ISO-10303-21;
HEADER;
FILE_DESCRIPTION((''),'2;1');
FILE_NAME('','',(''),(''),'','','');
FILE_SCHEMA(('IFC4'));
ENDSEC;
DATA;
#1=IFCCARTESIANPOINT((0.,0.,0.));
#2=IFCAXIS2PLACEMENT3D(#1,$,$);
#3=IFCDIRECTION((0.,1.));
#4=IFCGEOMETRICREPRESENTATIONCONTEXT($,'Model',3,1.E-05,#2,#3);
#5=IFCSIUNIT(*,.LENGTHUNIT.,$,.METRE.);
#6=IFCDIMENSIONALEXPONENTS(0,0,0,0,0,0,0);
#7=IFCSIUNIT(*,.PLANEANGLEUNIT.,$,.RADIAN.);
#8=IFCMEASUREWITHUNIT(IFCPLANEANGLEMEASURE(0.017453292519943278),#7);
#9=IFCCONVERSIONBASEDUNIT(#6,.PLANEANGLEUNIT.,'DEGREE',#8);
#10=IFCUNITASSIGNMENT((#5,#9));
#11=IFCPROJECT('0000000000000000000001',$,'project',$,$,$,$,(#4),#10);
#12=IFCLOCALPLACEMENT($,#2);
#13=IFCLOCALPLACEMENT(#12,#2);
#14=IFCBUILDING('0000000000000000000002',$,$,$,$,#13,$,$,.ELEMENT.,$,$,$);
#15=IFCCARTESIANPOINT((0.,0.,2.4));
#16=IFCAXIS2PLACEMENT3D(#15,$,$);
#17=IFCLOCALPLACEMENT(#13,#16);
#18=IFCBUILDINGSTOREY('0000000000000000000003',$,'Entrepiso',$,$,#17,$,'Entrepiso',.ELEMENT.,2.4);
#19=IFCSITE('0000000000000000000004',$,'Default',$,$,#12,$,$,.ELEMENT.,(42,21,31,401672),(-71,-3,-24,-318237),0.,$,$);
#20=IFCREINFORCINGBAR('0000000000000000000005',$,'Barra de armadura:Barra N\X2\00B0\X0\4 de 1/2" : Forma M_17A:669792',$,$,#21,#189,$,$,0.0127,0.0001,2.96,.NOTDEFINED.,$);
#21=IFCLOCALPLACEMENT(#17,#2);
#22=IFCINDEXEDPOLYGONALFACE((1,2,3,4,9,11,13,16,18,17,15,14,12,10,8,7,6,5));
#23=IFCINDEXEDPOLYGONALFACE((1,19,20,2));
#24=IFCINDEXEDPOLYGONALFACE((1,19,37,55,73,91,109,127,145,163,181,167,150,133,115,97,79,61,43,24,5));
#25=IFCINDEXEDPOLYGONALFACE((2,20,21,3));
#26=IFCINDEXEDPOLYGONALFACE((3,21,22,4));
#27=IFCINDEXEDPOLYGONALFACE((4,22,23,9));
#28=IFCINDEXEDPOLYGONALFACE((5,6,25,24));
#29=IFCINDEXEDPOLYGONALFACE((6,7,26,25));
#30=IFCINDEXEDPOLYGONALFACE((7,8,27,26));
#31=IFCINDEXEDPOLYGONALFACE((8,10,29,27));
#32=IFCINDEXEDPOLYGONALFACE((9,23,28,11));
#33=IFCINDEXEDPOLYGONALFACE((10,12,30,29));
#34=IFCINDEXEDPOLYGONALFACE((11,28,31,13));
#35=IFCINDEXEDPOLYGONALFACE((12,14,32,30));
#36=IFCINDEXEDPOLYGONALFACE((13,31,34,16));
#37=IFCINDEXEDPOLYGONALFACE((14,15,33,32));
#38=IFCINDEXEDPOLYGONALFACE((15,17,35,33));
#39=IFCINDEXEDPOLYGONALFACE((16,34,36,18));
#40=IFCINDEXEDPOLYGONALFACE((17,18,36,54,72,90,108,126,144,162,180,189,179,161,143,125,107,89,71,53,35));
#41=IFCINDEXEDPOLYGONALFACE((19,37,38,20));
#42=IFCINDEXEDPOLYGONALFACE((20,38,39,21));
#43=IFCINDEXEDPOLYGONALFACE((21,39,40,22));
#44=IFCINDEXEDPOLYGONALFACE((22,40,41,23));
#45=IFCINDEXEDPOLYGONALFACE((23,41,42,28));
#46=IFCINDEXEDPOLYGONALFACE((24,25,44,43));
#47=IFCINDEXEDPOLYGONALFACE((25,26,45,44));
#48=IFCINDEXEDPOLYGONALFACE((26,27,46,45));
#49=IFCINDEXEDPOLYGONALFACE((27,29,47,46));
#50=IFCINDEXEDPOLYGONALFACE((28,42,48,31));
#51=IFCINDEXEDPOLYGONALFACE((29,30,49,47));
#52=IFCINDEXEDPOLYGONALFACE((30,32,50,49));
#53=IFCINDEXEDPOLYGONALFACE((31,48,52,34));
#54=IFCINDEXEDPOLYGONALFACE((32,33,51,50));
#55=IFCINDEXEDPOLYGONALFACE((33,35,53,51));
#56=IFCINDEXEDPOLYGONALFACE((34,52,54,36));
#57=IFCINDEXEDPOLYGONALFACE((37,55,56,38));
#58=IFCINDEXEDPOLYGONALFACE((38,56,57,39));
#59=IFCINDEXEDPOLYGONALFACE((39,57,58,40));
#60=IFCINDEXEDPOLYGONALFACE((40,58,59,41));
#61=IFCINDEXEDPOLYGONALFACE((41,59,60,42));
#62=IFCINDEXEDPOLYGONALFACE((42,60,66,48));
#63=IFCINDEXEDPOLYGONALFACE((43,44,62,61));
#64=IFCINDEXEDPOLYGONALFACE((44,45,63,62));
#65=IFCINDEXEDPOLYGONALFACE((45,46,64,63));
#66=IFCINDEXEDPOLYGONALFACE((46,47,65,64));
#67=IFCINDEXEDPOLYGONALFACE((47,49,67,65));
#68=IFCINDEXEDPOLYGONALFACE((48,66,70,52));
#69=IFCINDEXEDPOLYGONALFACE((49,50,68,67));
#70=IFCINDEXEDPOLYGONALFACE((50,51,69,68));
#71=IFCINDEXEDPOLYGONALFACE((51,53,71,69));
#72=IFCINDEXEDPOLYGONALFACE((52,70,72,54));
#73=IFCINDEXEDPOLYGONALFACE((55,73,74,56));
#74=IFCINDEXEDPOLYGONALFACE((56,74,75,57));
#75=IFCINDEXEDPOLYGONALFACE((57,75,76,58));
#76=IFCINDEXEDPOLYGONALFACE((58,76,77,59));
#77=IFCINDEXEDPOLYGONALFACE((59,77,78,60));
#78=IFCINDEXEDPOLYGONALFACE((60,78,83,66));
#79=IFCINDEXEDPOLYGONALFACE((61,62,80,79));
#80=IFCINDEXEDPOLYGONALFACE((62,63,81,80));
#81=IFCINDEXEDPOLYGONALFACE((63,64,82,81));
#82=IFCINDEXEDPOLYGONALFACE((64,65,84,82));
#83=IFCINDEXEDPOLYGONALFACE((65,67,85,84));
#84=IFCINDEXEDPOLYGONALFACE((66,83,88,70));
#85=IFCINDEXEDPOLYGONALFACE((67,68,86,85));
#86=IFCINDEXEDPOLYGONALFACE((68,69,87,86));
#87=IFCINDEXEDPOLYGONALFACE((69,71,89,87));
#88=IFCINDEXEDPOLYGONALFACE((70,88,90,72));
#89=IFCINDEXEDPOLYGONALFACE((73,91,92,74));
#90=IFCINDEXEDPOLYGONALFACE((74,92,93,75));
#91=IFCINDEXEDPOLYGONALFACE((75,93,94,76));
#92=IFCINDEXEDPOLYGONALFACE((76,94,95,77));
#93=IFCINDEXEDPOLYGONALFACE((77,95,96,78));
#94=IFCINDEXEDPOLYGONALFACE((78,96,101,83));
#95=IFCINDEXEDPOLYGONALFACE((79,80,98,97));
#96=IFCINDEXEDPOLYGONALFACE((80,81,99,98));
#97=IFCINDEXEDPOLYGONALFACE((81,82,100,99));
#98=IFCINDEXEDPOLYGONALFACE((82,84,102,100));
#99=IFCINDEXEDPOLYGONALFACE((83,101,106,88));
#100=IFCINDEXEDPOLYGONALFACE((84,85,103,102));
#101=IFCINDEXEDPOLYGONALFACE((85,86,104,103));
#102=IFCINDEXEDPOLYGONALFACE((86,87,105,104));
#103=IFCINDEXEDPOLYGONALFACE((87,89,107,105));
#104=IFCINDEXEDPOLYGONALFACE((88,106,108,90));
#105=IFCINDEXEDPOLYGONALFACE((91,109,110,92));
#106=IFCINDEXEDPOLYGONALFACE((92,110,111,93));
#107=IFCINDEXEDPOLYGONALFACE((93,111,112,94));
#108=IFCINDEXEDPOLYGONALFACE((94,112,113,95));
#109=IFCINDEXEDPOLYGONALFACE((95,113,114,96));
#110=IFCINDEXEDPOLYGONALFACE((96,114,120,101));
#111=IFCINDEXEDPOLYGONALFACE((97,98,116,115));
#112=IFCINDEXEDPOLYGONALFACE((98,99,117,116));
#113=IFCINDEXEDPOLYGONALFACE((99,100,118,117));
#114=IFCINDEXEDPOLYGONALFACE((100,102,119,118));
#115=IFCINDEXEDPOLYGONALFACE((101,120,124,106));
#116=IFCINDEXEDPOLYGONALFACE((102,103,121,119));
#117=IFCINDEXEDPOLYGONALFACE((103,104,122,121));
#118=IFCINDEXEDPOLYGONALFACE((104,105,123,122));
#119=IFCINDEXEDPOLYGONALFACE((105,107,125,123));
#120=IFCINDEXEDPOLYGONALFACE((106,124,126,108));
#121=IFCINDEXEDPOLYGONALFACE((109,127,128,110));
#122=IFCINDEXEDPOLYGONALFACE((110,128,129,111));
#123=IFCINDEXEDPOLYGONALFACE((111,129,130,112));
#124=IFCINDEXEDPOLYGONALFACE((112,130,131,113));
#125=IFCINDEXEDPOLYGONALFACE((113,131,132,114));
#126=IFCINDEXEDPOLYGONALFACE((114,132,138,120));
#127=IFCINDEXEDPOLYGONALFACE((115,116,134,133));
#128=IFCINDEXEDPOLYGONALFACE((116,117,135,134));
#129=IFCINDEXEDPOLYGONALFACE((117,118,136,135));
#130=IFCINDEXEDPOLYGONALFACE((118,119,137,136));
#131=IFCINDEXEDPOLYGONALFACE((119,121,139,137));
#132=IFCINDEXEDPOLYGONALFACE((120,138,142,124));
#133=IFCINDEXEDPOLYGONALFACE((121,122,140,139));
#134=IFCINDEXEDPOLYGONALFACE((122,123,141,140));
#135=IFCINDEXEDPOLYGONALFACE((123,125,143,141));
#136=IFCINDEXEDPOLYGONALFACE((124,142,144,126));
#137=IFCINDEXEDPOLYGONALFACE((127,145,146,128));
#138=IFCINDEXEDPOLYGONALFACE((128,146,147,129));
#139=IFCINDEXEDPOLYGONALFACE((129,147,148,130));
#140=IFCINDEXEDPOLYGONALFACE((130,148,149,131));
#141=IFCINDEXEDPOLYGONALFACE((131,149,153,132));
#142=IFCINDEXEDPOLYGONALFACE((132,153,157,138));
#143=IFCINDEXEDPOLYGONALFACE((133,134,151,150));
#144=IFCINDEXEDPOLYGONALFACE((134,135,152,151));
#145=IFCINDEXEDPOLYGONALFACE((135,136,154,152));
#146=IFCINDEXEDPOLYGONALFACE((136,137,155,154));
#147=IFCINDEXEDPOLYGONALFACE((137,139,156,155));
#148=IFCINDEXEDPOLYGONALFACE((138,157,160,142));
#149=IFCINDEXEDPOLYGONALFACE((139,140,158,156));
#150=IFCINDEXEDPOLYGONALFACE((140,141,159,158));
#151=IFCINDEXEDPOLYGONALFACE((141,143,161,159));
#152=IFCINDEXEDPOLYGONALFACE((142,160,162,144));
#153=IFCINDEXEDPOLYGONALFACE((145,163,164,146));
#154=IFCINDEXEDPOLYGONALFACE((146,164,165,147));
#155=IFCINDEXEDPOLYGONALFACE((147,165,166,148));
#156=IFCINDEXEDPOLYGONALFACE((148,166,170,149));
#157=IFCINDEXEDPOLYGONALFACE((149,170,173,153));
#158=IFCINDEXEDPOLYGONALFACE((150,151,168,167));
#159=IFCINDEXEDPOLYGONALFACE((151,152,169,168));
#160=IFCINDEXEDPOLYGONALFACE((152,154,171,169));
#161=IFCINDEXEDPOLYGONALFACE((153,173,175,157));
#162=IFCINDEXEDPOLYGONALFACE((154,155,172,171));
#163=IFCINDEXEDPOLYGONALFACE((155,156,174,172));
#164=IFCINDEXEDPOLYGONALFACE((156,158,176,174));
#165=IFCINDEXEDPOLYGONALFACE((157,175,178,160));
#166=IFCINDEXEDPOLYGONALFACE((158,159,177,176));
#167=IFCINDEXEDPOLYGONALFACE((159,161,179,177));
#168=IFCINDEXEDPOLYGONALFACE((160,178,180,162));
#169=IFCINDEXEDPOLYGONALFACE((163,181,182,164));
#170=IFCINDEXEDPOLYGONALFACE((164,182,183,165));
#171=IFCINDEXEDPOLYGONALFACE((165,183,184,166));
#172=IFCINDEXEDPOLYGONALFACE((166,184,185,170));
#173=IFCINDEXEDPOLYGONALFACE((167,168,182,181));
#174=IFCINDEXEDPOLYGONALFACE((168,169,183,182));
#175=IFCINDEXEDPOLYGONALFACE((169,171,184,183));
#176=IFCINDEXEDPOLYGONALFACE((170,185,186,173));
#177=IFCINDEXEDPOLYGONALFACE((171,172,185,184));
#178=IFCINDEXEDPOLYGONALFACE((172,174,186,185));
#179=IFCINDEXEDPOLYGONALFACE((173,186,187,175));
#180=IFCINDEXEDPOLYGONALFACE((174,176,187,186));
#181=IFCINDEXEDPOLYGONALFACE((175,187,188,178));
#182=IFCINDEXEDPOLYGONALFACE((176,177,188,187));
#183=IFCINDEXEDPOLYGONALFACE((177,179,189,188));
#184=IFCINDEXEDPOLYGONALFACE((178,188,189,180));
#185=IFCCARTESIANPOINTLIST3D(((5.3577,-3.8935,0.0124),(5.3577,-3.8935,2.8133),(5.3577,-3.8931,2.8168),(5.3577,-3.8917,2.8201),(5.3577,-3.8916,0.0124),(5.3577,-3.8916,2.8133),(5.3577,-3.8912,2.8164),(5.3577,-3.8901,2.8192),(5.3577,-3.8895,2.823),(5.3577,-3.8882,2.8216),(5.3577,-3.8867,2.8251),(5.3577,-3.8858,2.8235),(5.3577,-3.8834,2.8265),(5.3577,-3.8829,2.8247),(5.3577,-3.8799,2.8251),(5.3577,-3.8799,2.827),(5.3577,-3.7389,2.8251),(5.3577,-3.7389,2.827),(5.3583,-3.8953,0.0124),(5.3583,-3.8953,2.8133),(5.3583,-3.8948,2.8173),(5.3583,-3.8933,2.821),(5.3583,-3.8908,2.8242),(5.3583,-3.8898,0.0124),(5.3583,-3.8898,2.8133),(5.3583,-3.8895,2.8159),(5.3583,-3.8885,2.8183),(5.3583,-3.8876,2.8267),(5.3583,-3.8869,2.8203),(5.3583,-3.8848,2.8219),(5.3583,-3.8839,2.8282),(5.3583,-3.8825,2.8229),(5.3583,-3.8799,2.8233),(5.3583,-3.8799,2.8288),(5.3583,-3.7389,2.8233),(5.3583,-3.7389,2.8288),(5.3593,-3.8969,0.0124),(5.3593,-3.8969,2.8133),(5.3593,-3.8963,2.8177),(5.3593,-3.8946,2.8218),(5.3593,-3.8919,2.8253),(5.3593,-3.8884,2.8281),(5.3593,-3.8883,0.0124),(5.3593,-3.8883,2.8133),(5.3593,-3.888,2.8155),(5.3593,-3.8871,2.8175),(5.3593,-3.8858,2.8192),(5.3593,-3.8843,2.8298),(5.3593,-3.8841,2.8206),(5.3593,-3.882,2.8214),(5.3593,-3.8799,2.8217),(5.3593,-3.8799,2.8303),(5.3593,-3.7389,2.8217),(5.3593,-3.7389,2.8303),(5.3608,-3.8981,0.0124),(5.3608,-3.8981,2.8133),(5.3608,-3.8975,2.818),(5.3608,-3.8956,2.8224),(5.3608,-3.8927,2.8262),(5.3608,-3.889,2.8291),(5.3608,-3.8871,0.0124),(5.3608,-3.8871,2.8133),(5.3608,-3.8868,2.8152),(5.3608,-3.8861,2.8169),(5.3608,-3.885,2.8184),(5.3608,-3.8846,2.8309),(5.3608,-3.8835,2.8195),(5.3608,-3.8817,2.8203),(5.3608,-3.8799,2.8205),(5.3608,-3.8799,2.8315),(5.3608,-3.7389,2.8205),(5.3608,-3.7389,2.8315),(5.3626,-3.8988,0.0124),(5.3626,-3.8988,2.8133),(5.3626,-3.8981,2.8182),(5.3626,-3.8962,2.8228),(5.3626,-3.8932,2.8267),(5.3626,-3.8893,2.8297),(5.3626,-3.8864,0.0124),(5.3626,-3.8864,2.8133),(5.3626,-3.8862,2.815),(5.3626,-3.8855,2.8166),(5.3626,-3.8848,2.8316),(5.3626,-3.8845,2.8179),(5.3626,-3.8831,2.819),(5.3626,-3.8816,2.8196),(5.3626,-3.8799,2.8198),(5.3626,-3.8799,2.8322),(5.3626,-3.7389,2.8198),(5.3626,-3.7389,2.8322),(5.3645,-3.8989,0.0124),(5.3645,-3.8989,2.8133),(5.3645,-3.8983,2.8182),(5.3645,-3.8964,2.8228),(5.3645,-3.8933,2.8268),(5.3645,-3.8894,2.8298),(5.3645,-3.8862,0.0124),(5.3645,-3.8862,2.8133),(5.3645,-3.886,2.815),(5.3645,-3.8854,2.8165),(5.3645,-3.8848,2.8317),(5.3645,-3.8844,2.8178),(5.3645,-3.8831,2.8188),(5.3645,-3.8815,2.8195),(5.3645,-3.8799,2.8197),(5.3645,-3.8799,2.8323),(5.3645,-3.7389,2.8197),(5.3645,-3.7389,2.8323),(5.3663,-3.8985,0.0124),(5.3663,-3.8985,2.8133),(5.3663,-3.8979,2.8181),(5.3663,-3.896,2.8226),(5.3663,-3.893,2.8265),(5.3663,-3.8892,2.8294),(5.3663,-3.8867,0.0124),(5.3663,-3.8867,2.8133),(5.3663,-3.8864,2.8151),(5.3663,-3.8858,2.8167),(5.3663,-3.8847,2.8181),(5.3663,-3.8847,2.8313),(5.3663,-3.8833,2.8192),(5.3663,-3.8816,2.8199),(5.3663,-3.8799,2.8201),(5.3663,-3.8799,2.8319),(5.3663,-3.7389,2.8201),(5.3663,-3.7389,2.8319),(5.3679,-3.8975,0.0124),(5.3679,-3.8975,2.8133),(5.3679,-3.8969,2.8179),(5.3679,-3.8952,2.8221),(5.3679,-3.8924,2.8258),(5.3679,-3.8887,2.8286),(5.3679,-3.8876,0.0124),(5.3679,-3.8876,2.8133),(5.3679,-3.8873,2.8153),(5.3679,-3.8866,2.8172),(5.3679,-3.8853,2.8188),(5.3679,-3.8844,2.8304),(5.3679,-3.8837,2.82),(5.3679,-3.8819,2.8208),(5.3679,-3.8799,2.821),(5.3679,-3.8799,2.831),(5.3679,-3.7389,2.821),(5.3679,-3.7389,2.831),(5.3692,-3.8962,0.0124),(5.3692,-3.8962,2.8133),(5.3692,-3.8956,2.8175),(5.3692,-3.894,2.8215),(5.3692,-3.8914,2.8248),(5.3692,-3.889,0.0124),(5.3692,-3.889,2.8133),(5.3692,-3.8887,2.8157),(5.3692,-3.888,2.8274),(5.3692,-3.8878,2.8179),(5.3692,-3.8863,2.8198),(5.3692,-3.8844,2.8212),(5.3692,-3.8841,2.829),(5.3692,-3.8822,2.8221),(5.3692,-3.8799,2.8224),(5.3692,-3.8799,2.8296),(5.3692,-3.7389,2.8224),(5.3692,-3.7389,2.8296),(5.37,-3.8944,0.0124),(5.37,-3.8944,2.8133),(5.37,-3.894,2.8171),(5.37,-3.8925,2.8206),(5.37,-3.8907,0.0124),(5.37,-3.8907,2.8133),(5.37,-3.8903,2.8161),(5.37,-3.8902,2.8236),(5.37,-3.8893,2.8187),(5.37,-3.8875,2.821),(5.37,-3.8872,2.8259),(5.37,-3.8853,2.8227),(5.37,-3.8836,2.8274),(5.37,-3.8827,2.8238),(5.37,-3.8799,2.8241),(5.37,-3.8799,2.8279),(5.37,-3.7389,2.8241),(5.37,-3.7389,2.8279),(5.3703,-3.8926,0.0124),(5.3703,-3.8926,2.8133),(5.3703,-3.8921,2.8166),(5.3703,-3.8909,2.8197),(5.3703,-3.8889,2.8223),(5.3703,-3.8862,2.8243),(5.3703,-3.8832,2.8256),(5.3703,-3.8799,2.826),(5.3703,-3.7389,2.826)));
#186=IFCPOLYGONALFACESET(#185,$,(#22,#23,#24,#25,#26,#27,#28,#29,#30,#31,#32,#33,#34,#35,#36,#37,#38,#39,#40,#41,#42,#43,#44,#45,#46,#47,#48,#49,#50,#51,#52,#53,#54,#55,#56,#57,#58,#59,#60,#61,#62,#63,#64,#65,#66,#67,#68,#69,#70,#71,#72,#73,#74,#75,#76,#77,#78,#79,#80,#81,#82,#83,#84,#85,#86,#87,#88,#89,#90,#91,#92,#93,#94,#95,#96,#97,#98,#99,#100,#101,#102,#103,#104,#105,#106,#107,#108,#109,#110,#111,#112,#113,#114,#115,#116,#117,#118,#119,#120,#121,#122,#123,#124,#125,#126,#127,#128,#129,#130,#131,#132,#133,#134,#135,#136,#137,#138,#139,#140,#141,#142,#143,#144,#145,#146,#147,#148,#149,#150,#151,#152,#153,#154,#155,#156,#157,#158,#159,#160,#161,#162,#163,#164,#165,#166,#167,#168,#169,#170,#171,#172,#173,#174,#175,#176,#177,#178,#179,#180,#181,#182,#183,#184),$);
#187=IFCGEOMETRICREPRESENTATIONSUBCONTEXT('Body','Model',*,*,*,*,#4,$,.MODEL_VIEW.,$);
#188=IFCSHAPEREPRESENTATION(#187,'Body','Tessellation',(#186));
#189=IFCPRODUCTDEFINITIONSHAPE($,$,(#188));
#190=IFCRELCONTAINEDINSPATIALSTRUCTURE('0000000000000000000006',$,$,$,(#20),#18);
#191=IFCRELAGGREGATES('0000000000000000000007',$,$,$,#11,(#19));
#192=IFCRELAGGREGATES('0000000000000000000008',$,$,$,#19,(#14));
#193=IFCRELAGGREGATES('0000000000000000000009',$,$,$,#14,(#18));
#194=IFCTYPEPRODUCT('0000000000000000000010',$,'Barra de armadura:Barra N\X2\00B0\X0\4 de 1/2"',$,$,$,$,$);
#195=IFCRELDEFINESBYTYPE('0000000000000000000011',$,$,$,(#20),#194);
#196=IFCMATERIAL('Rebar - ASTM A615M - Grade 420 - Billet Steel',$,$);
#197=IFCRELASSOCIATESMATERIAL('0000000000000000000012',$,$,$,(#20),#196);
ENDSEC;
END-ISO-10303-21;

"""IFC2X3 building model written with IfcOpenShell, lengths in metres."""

from ifc_helpers import new_model, entity, si_unit, converted_unit, direction, frame, origin, place, context, subcontext, project, spatial, material, type_object, element, save


model = new_model("IFC2X3")

# Units and contexts
model_context = context("Model", 3, precision=1e-05, world=origin(), true_north=direction((0.0, 1.0)))
body_context = subcontext(model_context, "Body", "Model", "MODEL_VIEW")
ifc_project = project(units=[si_unit("LENGTHUNIT", "METRE"), converted_unit("PLANEANGLEUNIT", "DEGREE", entity("IfcPlaneAngleMeasure", 0.017453292519943278), si_unit("PLANEANGLEUNIT", "RADIAN"), dimensions=[0, 0, 0, 0, 0, 0, 0])], contexts=[model_context])

# Site, building, storey
site_placement = place(None, origin())
site = spatial("IfcSite", under=ifc_project, at=site_placement, Name="Default", CompositionType="ELEMENT", RefLatitude=(42, 21, 31, 401672), RefLongitude=(-71, -3, -24, -318237), RefElevation=0.0)
building_placement = place(site_placement, origin())
building = spatial("IfcBuilding", under=site, at=building_placement, CompositionType="ELEMENT")
storey_placement = place(building_placement, frame((0.0, 0.0, 2.4)))
storey = spatial("IfcBuildingStorey", under=building, at=storey_placement, Name="Entrepiso", LongName="Entrepiso", CompositionType="ELEMENT", Elevation=2.4)

# Reinforcing bar
ifc_material = material(Name="Rebar - ASTM A615M - Grade 420 - Billet Steel")
type_product_1 = type_object("IfcTypeProduct", Name="Barra de armadura:Barra N°4 de 1/2\"")
reinforcing_bar_1_placement = place(storey_placement, origin())
element("IfcReinforcingBar", 1, at=reinforcing_bar_1_placement, inside=storey, type_object=type_product_1, material=ifc_material, Name="Barra de armadura:Barra N°4 de 1/2\" : Forma M_17A:669792", BarLength=2.96, BarRole="NOTDEFINED", CrossSectionArea=0.0001, NominalDiameter=0.0127, context=body_context, shape_type="AdvancedSweptSolid", body=[
    entity("IfcSweptDiskSolid", entity("IfcCompositeCurve", [entity("IfcCompositeCurveSegment", "CONTINUOUS", True, entity("IfcPolyline", [entity("IfcCartesianPoint", [5.364, -3.8926, 0.0124]), entity("IfcCartesianPoint", [5.364, -3.8926, 2.8133])])), entity("IfcCompositeCurveSegment", "CONTINUOUS", True, entity("IfcTrimmedCurve", entity("IfcCircle", entity("IfcAxis2Placement3D", entity("IfcCartesianPoint", [5.364, -3.8799, 2.8133]), entity("IfcDirection", [-1.0, 0.0, 0.0]), entity("IfcDirection", [0.0, 0.0, 1.0])), 0.0127), [entity("IfcParameterValue", 270.0)], [entity("IfcParameterValue", 360.0)], True, "PARAMETER")), entity("IfcCompositeCurveSegment", "CONTINUOUS", True, entity("IfcPolyline", [entity("IfcCartesianPoint", [5.364, -3.8799, 2.826]), entity("IfcCartesianPoint", [5.364, -3.7389, 2.826])]))], False), 0.0063, None, 0.0, 92.0),
])

save(model, "model.ifc")
